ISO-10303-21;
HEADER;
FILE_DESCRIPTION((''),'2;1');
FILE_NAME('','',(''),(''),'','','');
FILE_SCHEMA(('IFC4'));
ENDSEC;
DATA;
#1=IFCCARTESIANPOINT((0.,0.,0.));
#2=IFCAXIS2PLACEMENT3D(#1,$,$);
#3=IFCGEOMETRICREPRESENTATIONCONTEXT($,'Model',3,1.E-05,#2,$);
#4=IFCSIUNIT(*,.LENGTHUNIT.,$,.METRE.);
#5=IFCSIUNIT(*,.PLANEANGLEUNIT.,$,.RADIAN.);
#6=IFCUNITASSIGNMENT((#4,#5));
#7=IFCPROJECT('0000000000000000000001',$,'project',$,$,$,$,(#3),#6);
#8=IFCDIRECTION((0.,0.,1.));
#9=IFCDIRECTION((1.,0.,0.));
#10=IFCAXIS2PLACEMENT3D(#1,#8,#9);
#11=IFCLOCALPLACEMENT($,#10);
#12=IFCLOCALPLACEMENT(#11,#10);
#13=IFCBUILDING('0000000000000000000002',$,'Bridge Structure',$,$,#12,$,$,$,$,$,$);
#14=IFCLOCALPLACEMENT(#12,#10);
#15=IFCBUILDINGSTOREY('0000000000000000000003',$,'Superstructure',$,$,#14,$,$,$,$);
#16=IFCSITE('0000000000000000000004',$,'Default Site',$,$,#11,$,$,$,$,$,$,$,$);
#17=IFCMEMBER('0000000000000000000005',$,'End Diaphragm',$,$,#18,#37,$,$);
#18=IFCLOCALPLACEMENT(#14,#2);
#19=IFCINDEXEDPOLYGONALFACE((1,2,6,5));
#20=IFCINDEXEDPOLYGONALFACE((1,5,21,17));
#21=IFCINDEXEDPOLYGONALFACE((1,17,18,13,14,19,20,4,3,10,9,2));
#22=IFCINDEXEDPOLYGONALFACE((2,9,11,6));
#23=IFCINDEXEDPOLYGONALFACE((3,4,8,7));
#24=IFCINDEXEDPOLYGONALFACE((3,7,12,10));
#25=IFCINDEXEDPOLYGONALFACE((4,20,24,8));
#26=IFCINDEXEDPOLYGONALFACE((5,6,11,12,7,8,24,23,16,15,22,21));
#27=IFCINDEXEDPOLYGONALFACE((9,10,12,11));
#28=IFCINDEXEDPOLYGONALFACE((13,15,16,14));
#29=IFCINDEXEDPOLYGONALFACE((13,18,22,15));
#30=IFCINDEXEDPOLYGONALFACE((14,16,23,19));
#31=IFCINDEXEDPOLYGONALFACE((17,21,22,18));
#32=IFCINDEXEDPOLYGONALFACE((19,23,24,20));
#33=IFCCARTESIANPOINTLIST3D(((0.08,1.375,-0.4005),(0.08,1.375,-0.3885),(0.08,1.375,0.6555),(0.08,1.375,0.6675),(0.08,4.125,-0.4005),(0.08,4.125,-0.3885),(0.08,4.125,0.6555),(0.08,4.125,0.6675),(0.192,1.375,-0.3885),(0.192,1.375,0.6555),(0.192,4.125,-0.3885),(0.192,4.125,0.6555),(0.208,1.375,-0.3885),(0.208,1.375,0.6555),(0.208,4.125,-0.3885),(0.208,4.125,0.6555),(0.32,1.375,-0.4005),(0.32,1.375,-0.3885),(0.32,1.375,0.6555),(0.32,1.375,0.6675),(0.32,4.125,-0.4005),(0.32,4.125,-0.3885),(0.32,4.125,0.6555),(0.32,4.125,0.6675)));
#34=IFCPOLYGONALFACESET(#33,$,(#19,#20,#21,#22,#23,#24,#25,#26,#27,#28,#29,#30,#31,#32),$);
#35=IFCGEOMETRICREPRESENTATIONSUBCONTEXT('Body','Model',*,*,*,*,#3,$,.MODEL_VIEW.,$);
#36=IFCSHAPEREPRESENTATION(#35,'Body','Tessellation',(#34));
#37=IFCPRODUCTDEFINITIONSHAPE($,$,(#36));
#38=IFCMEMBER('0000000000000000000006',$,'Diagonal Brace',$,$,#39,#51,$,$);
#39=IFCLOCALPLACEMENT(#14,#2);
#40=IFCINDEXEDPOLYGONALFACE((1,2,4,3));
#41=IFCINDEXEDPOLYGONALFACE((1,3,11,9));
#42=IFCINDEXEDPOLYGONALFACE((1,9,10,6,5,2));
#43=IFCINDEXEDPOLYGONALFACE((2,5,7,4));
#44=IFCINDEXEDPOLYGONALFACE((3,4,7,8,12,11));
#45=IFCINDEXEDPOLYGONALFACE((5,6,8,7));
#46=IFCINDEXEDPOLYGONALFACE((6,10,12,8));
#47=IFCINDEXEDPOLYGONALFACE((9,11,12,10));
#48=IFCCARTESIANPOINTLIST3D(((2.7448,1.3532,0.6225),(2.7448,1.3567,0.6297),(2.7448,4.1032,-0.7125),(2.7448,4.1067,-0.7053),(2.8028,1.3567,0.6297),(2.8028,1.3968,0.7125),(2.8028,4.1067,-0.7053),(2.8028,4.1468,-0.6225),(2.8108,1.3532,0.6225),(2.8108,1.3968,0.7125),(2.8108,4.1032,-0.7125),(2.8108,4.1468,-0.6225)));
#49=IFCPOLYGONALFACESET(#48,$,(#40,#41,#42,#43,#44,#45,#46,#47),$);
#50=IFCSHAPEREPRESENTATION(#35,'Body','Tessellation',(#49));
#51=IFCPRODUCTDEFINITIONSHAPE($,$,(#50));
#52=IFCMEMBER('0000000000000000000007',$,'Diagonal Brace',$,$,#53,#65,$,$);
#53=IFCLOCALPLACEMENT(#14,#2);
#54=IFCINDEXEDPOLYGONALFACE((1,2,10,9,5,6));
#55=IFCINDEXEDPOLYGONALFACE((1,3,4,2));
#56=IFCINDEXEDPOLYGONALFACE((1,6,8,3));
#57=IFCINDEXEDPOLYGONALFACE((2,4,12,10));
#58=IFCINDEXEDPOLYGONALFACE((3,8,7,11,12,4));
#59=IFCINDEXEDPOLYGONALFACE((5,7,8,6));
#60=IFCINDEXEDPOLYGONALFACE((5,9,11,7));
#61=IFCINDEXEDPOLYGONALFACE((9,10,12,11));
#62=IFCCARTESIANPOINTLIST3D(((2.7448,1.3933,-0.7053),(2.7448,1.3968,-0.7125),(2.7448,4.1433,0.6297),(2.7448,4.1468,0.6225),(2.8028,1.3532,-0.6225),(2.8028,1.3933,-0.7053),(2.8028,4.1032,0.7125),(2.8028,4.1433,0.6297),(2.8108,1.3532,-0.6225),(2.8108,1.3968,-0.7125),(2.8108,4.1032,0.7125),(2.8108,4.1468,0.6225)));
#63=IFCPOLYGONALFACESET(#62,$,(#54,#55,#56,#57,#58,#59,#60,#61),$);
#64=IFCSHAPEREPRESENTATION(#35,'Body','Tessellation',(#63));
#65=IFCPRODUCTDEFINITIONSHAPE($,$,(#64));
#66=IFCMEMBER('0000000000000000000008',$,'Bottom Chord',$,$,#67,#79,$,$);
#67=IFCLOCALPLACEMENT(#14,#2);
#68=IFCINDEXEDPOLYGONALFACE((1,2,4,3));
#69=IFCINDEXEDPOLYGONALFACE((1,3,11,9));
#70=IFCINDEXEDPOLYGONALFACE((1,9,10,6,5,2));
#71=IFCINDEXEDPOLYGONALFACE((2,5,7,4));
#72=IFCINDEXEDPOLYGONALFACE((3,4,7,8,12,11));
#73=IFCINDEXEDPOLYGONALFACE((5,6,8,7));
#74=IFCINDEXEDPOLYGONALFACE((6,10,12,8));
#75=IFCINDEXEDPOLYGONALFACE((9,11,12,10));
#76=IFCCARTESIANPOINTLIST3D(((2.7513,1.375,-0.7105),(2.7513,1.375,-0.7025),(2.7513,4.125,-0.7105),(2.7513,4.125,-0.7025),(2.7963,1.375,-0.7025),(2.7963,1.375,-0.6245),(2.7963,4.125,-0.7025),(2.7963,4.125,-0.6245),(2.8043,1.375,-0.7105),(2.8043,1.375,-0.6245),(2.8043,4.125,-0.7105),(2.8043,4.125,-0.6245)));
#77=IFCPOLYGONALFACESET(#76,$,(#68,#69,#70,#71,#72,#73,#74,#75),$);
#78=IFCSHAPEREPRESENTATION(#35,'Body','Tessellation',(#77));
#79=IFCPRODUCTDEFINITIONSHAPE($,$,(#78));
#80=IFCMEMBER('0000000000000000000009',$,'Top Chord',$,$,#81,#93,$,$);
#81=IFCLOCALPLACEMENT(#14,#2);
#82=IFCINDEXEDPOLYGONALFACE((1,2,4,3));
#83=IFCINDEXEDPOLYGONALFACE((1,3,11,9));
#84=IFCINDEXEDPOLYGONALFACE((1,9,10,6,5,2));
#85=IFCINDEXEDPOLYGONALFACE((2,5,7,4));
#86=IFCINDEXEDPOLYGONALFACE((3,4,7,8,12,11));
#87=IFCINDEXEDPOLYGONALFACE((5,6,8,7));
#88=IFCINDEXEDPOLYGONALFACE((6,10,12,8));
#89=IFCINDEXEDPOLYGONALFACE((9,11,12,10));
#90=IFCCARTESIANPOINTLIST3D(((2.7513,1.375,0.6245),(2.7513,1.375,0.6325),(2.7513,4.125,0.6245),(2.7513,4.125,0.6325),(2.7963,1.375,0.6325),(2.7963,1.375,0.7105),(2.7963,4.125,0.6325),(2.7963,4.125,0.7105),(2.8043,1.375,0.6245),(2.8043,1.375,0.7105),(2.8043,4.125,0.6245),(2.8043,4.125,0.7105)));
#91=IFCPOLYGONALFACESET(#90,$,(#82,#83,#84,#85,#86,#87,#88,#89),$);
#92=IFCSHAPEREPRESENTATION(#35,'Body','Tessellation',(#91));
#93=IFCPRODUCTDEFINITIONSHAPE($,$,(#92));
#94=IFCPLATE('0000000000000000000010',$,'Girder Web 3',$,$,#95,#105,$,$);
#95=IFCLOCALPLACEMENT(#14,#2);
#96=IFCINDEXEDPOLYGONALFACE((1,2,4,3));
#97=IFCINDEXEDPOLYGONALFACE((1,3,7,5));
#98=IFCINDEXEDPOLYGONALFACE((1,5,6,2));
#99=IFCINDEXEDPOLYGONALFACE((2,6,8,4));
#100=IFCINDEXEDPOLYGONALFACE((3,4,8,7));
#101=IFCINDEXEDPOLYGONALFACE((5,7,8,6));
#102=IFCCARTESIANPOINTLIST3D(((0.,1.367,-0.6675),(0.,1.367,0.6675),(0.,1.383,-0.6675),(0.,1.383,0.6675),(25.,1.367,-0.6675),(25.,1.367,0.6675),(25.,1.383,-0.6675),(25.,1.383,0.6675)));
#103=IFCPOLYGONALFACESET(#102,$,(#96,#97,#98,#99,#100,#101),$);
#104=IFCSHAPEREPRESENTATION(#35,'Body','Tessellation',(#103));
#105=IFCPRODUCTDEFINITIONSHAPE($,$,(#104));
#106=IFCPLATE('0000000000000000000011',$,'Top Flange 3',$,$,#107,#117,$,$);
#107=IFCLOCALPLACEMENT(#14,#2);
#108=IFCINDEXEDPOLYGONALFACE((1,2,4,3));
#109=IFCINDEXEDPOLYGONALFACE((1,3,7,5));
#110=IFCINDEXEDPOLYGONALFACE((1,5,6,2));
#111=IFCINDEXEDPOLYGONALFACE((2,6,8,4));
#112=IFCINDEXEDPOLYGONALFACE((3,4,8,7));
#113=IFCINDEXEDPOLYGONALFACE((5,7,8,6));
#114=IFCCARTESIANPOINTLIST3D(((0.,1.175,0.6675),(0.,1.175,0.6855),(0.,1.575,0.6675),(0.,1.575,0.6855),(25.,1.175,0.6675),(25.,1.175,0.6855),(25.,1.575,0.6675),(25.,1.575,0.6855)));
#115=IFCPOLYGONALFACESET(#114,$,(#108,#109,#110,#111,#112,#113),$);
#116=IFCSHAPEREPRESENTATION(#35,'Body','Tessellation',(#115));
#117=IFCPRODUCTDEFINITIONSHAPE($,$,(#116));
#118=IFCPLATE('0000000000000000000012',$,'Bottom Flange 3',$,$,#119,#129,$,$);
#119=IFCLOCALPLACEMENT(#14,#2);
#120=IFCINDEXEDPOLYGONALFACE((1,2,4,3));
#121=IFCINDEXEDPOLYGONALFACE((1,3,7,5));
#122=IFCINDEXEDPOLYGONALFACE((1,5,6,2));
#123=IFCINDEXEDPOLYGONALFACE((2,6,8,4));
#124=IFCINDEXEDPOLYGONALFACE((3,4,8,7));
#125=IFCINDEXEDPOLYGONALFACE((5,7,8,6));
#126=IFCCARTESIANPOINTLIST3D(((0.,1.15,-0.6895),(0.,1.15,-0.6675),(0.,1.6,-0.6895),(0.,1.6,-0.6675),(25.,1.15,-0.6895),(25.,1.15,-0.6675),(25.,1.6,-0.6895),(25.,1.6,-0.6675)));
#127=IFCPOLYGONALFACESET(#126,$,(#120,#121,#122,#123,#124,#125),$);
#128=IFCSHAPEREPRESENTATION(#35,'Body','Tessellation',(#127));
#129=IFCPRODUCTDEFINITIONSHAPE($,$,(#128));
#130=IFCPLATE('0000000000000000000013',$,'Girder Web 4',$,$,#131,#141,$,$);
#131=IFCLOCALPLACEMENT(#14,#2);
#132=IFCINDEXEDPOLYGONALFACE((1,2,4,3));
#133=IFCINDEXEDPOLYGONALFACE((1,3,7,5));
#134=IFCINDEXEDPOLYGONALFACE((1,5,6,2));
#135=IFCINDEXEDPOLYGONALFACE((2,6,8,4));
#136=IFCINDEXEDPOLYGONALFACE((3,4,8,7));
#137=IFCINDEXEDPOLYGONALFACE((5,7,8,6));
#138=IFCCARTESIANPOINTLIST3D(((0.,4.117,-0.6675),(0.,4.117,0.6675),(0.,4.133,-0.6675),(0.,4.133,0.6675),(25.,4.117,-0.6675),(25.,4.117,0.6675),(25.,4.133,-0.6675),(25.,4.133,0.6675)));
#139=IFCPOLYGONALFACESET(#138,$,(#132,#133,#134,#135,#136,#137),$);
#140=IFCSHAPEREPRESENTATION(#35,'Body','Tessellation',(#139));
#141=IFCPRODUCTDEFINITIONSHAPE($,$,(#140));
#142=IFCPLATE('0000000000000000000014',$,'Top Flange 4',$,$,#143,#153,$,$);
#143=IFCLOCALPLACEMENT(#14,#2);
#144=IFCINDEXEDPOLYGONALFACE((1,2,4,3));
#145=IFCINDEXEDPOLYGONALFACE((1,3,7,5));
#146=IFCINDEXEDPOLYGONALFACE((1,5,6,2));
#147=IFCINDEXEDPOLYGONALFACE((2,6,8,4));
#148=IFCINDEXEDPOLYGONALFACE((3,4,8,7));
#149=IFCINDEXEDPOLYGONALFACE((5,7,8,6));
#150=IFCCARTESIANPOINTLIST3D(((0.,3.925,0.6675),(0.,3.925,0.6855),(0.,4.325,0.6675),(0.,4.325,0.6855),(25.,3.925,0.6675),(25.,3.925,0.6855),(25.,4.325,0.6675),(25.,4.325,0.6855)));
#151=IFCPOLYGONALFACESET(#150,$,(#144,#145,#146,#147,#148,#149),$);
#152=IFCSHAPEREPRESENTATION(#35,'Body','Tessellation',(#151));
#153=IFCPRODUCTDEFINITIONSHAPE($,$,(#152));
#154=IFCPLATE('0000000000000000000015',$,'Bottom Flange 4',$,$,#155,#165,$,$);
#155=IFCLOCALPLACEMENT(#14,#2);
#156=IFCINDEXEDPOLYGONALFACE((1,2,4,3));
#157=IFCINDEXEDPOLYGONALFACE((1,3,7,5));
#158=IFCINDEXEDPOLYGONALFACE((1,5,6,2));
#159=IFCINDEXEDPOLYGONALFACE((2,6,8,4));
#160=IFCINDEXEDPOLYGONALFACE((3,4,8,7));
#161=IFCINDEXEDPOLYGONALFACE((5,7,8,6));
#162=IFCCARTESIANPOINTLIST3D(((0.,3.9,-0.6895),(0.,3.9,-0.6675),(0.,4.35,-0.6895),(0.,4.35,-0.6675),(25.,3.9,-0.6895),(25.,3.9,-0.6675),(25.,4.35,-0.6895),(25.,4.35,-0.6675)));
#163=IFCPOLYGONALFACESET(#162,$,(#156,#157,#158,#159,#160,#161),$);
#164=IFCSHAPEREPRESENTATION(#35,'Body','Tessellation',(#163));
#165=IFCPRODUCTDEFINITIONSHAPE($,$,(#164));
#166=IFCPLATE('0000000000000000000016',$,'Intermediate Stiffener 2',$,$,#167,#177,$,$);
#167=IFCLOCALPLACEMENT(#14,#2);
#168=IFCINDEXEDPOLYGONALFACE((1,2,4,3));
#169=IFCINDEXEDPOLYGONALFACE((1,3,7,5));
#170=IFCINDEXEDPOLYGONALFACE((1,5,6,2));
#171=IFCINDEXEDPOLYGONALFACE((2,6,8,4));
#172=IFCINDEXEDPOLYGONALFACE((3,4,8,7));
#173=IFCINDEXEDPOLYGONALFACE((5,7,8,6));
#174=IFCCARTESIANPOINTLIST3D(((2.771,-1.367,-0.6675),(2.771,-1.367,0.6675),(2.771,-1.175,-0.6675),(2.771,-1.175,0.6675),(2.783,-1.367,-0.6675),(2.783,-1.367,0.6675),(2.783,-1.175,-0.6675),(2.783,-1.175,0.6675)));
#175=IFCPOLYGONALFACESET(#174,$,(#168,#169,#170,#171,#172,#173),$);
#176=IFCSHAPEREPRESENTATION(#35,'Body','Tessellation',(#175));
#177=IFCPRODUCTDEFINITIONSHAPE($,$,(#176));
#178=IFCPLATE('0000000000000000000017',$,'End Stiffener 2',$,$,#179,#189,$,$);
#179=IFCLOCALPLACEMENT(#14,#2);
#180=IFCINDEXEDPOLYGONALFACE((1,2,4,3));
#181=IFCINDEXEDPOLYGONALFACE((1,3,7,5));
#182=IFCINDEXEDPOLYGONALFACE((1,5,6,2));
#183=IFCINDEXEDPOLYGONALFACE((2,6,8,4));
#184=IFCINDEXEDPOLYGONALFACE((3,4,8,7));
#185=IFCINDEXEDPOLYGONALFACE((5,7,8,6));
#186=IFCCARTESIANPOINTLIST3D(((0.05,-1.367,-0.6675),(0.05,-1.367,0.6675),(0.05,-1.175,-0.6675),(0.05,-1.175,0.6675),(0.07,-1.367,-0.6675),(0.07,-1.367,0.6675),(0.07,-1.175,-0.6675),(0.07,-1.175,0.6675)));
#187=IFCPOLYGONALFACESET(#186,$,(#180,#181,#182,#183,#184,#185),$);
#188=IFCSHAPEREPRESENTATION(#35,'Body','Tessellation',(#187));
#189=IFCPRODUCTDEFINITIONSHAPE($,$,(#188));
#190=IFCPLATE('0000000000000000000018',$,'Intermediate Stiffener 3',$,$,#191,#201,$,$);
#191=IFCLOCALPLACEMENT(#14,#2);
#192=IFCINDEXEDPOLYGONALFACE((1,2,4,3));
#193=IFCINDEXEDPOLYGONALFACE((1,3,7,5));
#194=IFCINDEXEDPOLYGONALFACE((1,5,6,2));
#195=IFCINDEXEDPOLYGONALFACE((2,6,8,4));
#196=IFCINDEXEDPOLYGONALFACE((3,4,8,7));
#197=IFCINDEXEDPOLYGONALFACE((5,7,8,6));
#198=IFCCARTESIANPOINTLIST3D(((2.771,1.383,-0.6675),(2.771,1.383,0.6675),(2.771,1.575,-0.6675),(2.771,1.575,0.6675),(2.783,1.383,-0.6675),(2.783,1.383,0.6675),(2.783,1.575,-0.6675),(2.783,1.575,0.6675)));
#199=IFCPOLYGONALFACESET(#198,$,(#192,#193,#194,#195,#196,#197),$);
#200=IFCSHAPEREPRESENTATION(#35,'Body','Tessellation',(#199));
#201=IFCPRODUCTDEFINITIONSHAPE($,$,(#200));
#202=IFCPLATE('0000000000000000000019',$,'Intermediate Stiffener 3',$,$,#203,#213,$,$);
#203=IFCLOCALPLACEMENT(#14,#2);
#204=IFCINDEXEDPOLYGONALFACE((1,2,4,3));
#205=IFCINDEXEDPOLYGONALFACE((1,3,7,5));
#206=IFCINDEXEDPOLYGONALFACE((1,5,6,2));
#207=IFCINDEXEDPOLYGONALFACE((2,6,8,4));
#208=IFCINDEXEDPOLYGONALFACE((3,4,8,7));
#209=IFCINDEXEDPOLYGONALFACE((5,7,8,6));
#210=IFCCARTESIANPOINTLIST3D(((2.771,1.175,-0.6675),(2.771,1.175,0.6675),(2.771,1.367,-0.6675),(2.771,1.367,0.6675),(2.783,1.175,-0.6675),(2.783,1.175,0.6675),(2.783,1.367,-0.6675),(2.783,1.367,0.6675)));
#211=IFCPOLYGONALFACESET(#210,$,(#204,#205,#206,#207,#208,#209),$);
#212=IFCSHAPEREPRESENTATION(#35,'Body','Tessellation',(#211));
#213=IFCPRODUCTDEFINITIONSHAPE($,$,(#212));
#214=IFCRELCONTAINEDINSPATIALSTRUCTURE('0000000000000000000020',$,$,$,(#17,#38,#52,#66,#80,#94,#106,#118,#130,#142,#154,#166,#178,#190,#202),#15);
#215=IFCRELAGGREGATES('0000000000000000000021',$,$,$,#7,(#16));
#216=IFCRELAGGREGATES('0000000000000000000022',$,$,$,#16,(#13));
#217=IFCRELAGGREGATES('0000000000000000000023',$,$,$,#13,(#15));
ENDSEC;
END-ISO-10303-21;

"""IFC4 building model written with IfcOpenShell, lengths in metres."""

from ifc_helpers import new_model, si_unit, frame, origin, origin_with_axes, origin_2d_with_axis, place, context, subcontext, project, spatial, rectangle, i_section, l_section, extrude, element, save


model = new_model("IFC4")

# Units and contexts
model_context = context("Model", 3, precision=1e-05, world=origin())
body_context = subcontext(model_context, "Body", "Model", "MODEL_VIEW")
ifc_project = project(units=[si_unit("LENGTHUNIT", "METRE"), si_unit("PLANEANGLEUNIT", "RADIAN")], contexts=[model_context])

# Site, building, storey
site_placement = place(None, origin_with_axes())
site = spatial("IfcSite", under=ifc_project, at=site_placement, Name="Default Site")
building_placement = place(site_placement, origin_with_axes())
building = spatial("IfcBuilding", under=site, at=building_placement, Name="Bridge Structure")
storey_placement = place(building_placement, origin_with_axes())
storey = spatial("IfcBuildingStorey", under=building, at=storey_placement, Name="Superstructure")

# Members
member_placement = place(storey_placement, frame((0.2, 1.375, 0.1335), z_axis=(0.0, 1.0, 0.0), x_axis=(-1.0, 0.0, 0.0)))
element("IfcMember", 1, at=member_placement, inside=storey, Name="End Diaphragm", context=body_context, shape_type="SweptSolid", body=[
    extrude(i_section(OverallWidth=0.24, OverallDepth=1.068, WebThickness=0.016, FlangeThickness=0.012, at=origin_2d_with_axis()), origin_with_axes(), (0.0, 0.0, 1.0), 2.75),
])
for number, where, z_axis, x_axis, name in (
    (2, (2.7778, 1.375, 0.6675), (0.0, 0.8996, -0.436715), (-1.0, 0.0, 0.0), "Diagonal Brace"),
    (3, (2.7778, 1.375, -0.6675), (0.0, 0.8996, 0.436715), (-1.0, 0.0, 0.0), "Diagonal Brace"),
):
    element("IfcMember", number, at=place(storey_placement, frame(where, z_axis=z_axis, x_axis=x_axis)), inside=storey, Name=name, context=body_context, shape_type="SweptSolid", body=[
        extrude(l_section(Depth=0.1, Width=0.066, Thickness=0.008, at=origin_2d_with_axis()), origin_with_axes(), (0.0, 0.0, 1.0), 3.0569),
    ])
for number, where, z_axis, x_axis, name in (
    (4, (2.7778, 1.375, -0.6675), (0.0, 1.0, 0.0), (-1.0, 0.0, 0.0), "Bottom Chord"),
    (5, (2.7778, 1.375, 0.6675), (0.0, 1.0, 0.0), (-1.0, 0.0, 0.0), "Top Chord"),
):
    element("IfcMember", number, at=place(storey_placement, frame(where, z_axis=z_axis, x_axis=x_axis)), inside=storey, Name=name, context=body_context, shape_type="SweptSolid", body=[
        extrude(l_section(Depth=0.086, Width=0.053, Thickness=0.008, at=origin_2d_with_axis()), origin_with_axes(), (0.0, 0.0, 1.0), 2.75),
    ])

# Plates
plate_1_placement = place(storey_placement, frame((0.0, 1.375, 0.0), z_axis=(1.0, 0.0, 0.0), x_axis=(0.0, 1.0, 0.0)))
element("IfcPlate", 6, at=plate_1_placement, inside=storey, Name="Girder Web 3", context=body_context, shape_type="SweptSolid", body=[
    extrude(rectangle(XDim=0.016, YDim=1.335, at=origin_2d_with_axis()), origin_with_axes(), (0.0, 0.0, 1.0), 25.0),
])
plate_2_placement = place(storey_placement, frame((0.0, 1.375, 0.6765), z_axis=(1.0, 0.0, 0.0), x_axis=(0.0, 1.0, 0.0)))
element("IfcPlate", 7, at=plate_2_placement, inside=storey, Name="Top Flange 3", context=body_context, shape_type="SweptSolid", body=[
    extrude(rectangle(XDim=0.4, YDim=0.018, at=origin_2d_with_axis()), origin_with_axes(), (0.0, 0.0, 1.0), 25.0),
])
plate_3_placement = place(storey_placement, frame((0.0, 1.375, -0.6785), z_axis=(1.0, 0.0, 0.0), x_axis=(0.0, 1.0, 0.0)))
element("IfcPlate", 8, at=plate_3_placement, inside=storey, Name="Bottom Flange 3", context=body_context, shape_type="SweptSolid", body=[
    extrude(rectangle(XDim=0.45, YDim=0.022, at=origin_2d_with_axis()), origin_with_axes(), (0.0, 0.0, 1.0), 25.0),
])
plate_4_placement = place(storey_placement, frame((0.0, 4.125, 0.0), z_axis=(1.0, 0.0, 0.0), x_axis=(0.0, 1.0, 0.0)))
element("IfcPlate", 9, at=plate_4_placement, inside=storey, Name="Girder Web 4", context=body_context, shape_type="SweptSolid", body=[
    extrude(rectangle(XDim=0.016, YDim=1.335, at=origin_2d_with_axis()), origin_with_axes(), (0.0, 0.0, 1.0), 25.0),
])
plate_5_placement = place(storey_placement, frame((0.0, 4.125, 0.6765), z_axis=(1.0, 0.0, 0.0), x_axis=(0.0, 1.0, 0.0)))
element("IfcPlate", 10, at=plate_5_placement, inside=storey, Name="Top Flange 4", context=body_context, shape_type="SweptSolid", body=[
    extrude(rectangle(XDim=0.4, YDim=0.018, at=origin_2d_with_axis()), origin_with_axes(), (0.0, 0.0, 1.0), 25.0),
])
plate_6_placement = place(storey_placement, frame((0.0, 4.125, -0.6785), z_axis=(1.0, 0.0, 0.0), x_axis=(0.0, 1.0, 0.0)))
element("IfcPlate", 11, at=plate_6_placement, inside=storey, Name="Bottom Flange 4", context=body_context, shape_type="SweptSolid", body=[
    extrude(rectangle(XDim=0.45, YDim=0.022, at=origin_2d_with_axis()), origin_with_axes(), (0.0, 0.0, 1.0), 25.0),
])
plate_7_placement = place(storey_placement, frame((2.777, -1.271, -0.6675), z_axis=(0.0, 0.0, 1.0), x_axis=(1.0, 0.0, 0.0)))
element("IfcPlate", 12, at=plate_7_placement, inside=storey, Name="Intermediate Stiffener 2", context=body_context, shape_type="SweptSolid", body=[
    extrude(rectangle(XDim=0.012, YDim=0.192, at=origin_2d_with_axis()), origin_with_axes(), (0.0, 0.0, 1.0), 1.335),
])
plate_8_placement = place(storey_placement, frame((0.06, -1.271, -0.6675), z_axis=(0.0, 0.0, 1.0), x_axis=(1.0, 0.0, 0.0)))
element("IfcPlate", 13, at=plate_8_placement, inside=storey, Name="End Stiffener 2", context=body_context, shape_type="SweptSolid", body=[
    extrude(rectangle(XDim=0.02, YDim=0.192, at=origin_2d_with_axis()), origin_with_axes(), (0.0, 0.0, 1.0), 1.335),
])
for number, where, z_axis, x_axis, name in (
    (14, (2.777, 1.479, -0.6675), (0.0, 0.0, 1.0), (1.0, 0.0, 0.0), "Intermediate Stiffener 3"),
    (15, (2.777, 1.271, -0.6675), (0.0, 0.0, 1.0), (1.0, 0.0, 0.0), "Intermediate Stiffener 3"),
):
    element("IfcPlate", number, at=place(storey_placement, frame(where, z_axis=z_axis, x_axis=x_axis)), inside=storey, Name=name, context=body_context, shape_type="SweptSolid", body=[
        extrude(rectangle(XDim=0.012, YDim=0.192, at=origin_2d_with_axis()), origin_with_axes(), (0.0, 0.0, 1.0), 1.335),
    ])

save(model, "model.ifc")
